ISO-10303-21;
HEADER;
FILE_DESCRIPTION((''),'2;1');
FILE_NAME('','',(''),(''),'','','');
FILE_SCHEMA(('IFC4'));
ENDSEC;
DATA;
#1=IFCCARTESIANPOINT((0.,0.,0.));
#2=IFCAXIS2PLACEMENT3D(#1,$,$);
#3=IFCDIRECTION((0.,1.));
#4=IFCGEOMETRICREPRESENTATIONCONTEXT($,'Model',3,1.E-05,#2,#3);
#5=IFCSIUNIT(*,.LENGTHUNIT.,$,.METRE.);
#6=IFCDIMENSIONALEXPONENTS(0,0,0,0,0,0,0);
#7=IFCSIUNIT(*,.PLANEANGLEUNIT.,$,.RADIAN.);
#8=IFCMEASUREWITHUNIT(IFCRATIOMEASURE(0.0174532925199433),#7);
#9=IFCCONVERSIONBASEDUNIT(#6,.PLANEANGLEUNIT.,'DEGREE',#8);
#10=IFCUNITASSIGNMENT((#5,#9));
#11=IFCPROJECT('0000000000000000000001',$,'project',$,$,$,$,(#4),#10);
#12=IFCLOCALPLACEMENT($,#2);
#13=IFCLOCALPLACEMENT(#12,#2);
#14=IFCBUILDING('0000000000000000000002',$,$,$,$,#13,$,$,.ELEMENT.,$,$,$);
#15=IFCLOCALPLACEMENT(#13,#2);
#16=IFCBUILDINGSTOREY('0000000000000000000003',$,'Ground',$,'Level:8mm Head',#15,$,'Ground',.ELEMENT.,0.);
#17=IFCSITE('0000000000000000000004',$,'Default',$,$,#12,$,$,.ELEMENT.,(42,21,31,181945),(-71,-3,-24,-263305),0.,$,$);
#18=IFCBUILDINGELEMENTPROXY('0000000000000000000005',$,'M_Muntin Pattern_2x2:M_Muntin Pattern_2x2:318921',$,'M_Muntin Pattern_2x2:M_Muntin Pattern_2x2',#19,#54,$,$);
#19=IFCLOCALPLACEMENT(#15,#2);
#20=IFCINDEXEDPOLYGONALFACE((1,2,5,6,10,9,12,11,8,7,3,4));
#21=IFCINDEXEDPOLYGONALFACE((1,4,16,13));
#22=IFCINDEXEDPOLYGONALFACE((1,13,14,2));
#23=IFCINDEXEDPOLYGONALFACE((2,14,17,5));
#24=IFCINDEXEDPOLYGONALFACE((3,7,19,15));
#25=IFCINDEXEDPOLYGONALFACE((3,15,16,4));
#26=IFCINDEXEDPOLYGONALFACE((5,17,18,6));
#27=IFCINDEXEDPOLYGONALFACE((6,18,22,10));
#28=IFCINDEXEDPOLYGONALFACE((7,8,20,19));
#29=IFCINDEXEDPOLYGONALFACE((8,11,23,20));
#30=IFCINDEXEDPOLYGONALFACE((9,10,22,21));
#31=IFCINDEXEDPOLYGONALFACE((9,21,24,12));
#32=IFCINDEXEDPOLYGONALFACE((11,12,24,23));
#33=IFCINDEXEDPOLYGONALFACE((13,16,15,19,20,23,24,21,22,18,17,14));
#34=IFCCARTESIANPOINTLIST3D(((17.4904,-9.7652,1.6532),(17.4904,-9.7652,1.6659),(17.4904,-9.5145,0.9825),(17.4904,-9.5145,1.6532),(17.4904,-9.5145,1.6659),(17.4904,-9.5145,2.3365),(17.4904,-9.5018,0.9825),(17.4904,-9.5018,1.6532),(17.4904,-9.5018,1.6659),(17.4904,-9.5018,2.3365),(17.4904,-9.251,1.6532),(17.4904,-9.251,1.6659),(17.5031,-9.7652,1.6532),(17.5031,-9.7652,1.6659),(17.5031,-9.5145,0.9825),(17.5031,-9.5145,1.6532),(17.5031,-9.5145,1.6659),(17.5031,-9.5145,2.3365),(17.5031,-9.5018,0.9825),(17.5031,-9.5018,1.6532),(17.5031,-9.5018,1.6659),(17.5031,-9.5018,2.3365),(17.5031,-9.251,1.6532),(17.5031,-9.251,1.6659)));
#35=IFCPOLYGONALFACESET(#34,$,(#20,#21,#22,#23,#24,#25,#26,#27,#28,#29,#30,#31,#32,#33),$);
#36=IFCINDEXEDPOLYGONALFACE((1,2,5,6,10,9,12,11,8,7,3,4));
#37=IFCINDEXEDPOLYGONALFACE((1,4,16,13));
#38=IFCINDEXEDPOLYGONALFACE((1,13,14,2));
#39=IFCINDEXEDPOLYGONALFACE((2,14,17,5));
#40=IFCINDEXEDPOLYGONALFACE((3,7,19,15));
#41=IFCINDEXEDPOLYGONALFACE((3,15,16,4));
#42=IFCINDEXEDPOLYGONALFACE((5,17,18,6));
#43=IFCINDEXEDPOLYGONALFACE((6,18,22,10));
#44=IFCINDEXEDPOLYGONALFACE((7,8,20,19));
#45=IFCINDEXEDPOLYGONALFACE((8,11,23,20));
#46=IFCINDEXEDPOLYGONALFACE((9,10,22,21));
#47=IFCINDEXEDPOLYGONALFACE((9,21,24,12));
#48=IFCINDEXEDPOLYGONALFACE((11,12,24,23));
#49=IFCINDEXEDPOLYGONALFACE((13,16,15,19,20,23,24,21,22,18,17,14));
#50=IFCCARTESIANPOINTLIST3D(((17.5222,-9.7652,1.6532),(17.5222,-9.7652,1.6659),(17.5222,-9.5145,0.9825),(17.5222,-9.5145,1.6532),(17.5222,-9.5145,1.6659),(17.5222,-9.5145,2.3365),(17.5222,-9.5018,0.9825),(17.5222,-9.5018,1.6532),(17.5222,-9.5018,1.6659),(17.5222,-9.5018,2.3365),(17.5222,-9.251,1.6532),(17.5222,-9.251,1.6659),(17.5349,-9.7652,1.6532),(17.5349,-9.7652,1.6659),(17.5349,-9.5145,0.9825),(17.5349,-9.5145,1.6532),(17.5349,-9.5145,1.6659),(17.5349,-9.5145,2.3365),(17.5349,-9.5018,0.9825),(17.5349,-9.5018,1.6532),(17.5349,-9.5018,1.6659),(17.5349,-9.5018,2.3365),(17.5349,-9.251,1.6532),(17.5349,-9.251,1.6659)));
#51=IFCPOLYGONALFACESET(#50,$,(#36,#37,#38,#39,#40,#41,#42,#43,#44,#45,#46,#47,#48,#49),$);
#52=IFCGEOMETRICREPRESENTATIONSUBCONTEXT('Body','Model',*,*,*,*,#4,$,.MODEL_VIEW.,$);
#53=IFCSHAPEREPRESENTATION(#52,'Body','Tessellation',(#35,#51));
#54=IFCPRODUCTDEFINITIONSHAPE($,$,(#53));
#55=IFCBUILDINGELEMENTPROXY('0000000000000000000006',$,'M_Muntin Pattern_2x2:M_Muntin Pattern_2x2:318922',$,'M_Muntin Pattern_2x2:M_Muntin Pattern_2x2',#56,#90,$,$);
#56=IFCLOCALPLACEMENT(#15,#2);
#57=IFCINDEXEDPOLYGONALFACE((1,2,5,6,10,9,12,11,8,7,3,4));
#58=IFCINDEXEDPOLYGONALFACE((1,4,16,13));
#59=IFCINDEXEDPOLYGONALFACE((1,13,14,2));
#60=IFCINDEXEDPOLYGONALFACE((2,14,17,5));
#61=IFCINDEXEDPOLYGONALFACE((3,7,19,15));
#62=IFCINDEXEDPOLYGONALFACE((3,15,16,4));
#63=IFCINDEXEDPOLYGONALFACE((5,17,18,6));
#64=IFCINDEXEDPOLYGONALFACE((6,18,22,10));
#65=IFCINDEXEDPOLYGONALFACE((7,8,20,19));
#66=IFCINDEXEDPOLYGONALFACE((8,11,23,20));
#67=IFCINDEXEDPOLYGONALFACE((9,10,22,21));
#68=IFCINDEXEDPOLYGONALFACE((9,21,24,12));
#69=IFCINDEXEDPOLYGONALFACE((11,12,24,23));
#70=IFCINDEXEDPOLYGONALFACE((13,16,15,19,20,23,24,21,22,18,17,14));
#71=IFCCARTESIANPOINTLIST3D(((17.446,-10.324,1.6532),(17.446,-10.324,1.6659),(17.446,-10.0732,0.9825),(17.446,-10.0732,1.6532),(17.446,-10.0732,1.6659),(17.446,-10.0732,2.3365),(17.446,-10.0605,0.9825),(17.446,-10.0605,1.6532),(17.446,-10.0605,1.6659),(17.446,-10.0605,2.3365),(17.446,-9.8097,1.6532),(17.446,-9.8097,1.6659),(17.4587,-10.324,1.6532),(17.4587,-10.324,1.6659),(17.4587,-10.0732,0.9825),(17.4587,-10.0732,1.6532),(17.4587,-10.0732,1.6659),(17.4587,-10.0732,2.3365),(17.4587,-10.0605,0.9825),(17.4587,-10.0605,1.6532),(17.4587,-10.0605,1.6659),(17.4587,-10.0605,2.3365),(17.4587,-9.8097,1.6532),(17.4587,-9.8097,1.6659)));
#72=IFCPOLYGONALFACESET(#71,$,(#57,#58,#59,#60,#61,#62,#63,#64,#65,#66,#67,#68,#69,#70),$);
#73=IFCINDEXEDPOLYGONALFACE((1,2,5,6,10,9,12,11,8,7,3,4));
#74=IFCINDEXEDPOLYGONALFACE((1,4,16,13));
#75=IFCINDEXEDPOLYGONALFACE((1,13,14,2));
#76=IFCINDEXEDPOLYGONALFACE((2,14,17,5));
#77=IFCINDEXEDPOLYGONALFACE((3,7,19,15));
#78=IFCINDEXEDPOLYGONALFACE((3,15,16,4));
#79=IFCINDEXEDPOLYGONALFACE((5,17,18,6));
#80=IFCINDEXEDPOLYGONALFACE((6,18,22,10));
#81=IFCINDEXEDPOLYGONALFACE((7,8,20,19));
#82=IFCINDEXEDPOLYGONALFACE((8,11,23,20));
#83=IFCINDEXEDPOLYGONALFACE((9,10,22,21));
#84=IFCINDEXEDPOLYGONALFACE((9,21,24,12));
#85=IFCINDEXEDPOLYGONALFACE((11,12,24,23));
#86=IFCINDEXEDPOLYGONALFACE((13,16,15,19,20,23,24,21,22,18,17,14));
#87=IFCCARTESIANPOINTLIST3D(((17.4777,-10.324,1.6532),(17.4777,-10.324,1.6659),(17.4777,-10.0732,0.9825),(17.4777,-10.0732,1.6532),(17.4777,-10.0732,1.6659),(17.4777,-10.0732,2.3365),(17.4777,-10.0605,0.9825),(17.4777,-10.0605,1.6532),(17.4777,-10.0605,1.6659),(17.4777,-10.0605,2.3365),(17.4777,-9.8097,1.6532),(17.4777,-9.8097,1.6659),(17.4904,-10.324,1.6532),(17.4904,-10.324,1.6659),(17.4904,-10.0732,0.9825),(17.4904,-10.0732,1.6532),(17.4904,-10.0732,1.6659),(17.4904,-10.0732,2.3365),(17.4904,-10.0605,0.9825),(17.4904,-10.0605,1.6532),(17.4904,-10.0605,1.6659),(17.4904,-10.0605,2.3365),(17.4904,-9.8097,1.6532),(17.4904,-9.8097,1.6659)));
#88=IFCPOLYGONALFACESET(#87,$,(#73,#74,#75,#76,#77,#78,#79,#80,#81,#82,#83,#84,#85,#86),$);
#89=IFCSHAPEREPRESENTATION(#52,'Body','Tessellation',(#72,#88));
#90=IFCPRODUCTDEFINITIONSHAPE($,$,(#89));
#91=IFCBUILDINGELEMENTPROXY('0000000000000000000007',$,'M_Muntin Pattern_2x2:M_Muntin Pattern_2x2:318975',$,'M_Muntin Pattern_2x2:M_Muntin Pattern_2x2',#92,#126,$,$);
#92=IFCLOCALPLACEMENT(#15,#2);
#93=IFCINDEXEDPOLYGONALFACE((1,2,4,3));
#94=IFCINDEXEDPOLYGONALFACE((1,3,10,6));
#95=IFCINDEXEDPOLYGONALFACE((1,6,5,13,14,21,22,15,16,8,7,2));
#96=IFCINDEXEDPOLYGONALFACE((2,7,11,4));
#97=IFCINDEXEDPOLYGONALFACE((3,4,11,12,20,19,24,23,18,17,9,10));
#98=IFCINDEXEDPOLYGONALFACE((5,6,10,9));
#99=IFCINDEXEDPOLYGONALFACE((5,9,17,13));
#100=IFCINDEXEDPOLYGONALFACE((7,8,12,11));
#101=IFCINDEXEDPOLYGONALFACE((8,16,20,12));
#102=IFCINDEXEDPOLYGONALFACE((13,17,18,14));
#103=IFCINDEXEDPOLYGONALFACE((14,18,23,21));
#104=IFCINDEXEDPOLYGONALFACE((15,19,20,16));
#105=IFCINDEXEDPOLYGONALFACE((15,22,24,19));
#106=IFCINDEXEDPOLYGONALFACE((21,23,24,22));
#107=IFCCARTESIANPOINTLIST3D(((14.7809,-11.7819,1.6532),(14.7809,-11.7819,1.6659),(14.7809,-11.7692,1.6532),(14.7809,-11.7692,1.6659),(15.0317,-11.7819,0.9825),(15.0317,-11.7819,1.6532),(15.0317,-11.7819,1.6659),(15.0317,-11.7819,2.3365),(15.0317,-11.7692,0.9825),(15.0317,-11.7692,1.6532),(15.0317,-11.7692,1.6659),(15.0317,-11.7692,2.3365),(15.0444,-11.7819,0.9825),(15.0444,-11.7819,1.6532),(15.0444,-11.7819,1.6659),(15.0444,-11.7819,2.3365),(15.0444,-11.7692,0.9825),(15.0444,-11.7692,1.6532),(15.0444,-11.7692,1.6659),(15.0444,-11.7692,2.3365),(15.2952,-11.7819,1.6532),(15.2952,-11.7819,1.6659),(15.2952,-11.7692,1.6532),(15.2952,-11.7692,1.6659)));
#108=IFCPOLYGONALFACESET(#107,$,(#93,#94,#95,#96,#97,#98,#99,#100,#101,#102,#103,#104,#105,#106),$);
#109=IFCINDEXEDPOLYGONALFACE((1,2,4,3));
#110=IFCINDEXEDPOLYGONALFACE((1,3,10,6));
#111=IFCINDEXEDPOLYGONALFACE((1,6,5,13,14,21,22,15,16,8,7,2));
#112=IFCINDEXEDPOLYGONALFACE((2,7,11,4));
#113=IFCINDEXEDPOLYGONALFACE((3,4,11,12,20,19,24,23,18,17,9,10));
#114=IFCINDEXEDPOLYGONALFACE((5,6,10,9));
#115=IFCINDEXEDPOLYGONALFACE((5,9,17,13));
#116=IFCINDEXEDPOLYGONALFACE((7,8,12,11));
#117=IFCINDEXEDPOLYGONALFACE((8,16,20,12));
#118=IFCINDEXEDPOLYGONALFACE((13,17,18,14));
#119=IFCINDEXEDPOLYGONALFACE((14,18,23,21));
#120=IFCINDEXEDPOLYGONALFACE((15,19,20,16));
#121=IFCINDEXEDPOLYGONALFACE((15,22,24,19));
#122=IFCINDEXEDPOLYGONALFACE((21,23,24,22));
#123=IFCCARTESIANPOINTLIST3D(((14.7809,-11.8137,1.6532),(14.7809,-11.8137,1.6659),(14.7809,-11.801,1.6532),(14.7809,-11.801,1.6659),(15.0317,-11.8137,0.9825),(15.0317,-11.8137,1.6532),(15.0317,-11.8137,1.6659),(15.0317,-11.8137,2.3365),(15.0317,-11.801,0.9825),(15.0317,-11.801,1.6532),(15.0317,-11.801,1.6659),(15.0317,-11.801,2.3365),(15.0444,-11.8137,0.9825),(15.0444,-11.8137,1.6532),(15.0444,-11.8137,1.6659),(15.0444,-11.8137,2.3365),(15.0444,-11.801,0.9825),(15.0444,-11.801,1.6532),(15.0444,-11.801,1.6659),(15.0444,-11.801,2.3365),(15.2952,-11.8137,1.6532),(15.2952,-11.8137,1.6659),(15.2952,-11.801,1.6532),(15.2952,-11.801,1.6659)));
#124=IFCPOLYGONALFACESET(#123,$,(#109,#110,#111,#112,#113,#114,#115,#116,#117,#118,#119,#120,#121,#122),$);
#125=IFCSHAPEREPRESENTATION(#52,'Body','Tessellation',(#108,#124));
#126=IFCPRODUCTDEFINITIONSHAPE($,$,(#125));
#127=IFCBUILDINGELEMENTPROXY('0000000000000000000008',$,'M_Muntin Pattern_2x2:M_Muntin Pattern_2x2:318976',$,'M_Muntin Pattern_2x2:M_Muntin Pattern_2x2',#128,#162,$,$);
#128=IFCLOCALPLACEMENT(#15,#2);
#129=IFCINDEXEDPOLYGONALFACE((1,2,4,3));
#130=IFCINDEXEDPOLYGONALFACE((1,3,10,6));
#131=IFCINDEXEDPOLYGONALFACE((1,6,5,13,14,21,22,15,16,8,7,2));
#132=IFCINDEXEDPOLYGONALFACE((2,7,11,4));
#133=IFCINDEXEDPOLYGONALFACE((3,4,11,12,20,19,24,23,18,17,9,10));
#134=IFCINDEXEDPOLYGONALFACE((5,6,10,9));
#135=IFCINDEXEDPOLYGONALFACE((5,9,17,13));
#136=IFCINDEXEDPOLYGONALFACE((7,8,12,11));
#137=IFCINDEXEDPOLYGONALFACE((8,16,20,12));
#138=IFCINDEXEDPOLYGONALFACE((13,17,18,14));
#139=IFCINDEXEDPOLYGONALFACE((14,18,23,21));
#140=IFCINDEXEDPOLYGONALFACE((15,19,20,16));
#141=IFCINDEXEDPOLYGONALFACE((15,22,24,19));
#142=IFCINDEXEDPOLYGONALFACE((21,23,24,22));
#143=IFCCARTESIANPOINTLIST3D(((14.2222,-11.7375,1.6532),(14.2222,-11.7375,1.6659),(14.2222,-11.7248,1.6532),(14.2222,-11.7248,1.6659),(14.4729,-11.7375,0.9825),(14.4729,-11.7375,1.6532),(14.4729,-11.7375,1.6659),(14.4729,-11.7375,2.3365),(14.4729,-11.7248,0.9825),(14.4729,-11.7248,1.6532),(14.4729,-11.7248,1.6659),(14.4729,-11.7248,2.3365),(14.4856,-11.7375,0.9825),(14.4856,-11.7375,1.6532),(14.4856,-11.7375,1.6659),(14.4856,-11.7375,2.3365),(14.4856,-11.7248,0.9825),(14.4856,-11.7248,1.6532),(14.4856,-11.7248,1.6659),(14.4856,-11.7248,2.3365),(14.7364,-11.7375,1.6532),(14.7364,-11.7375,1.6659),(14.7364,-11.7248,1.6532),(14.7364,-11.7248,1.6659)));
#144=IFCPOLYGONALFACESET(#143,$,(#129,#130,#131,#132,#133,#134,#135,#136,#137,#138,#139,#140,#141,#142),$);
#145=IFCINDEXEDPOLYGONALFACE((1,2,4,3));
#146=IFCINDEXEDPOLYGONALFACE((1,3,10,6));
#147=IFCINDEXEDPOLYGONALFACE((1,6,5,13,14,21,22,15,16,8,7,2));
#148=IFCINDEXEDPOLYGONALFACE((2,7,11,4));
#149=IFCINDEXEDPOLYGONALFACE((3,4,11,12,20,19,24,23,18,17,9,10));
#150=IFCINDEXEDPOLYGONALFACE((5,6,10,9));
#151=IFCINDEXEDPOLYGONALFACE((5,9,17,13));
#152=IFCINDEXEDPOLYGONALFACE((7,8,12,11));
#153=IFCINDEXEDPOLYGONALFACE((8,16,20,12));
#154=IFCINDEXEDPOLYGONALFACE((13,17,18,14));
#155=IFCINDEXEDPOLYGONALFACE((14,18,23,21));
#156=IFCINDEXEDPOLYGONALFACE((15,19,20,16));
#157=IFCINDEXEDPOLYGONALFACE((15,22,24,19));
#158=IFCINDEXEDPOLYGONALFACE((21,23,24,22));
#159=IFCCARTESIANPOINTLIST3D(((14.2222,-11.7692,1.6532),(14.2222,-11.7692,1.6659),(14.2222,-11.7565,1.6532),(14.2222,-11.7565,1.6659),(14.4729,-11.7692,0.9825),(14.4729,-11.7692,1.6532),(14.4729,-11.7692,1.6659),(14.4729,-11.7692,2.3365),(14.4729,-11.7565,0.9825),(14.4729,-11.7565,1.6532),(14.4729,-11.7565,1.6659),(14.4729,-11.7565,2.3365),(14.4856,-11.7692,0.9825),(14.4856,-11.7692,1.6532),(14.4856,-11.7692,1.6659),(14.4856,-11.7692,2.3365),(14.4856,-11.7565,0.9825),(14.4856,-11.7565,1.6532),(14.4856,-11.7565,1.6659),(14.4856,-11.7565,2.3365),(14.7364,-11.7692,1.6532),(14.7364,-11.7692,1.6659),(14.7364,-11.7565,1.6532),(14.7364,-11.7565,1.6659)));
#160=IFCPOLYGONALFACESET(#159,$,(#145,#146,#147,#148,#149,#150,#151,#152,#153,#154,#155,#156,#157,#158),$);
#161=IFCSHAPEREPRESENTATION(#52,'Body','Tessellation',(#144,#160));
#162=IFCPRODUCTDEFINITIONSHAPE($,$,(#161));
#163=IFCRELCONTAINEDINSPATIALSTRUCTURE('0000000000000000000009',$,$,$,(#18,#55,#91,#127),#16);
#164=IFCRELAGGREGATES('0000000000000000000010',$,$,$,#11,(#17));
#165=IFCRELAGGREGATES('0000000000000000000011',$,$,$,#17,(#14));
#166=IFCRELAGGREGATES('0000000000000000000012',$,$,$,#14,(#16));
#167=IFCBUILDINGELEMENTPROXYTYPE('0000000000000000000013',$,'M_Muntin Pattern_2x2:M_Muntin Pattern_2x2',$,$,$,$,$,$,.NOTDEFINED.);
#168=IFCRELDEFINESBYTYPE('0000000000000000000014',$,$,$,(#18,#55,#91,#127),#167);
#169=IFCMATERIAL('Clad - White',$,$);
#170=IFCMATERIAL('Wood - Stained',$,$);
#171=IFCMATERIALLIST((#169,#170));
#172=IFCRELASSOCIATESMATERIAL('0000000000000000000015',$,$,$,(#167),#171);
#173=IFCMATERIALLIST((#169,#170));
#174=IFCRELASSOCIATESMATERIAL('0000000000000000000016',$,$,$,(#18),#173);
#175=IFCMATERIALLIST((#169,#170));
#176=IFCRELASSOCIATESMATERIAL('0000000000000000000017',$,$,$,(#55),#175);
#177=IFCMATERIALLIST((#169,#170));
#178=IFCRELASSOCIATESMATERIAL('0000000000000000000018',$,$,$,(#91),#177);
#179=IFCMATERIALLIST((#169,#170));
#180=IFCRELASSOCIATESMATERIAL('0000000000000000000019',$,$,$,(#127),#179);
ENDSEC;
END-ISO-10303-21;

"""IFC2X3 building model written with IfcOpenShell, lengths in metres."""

from ifc_helpers import new_model, entity, si_unit, converted_unit, direction, frame, origin, place, context, subcontext, project, spatial, polyline, outline, extrude, source, transform, mapped, material, material_list, type_object, type_shapes, element, save


model = new_model("IFC2X3")

# Units and contexts
model_context = context("Model", 3, precision=1e-05, world=origin(), true_north=direction((0.0, 1.0)))
body_context = subcontext(model_context, "Body", "Model", "MODEL_VIEW")
ifc_project = project(units=[si_unit("LENGTHUNIT", "METRE"), converted_unit("PLANEANGLEUNIT", "DEGREE", entity("IfcRatioMeasure", 0.0174532925199433), si_unit("PLANEANGLEUNIT", "RADIAN"), dimensions=[0, 0, 0, 0, 0, 0, 0])], contexts=[model_context])

# Site, building, storey
site_placement = place(None, origin())
site = spatial("IfcSite", under=ifc_project, at=site_placement, Name="Default", CompositionType="ELEMENT", RefLatitude=(42, 21, 31, 181945), RefLongitude=(-71, -3, -24, -263305), RefElevation=0.0)
building_placement = place(site_placement, origin())
building = spatial("IfcBuilding", under=site, at=building_placement, CompositionType="ELEMENT")
storey_placement = place(building_placement, origin())
storey = spatial("IfcBuildingStorey", under=building, at=storey_placement, Name="Ground", ObjectType="Level:8mm Head", LongName="Ground", CompositionType="ELEMENT", Elevation=0.0)

# Building element proxies
ifc_material_1 = material(Name="Clad - White")
ifc_material_2 = material(Name="Wood - Stained")
ifc_material_list_1 = material_list([ifc_material_1, ifc_material_2])
building_element_proxy_type_1 = type_object("IfcBuildingElementProxyType", Name="M_Muntin Pattern_2x2:M_Muntin Pattern_2x2", PredefinedType="NOTDEFINED", material=ifc_material_list_1)
shared_shape_1 = source(origin(), body_context, "Body", "SweptSolid", [
    extrude(outline(polyline([(0.0064, -0.0064), (0.677, -0.0064), (0.677, 0.0063), (0.0064, 0.0063), (0.0064, 0.2571), (-0.0063, 0.2571), (-0.0063, 0.0063), (-0.677, 0.0063), (-0.677, -0.0064), (-0.0063, -0.0064), (-0.0063, -0.2571), (0.0064, -0.2571), (0.0064, -0.0064)])), frame((0.0, 0.0095, 0.677), z_axis=(0.0, 1.0, 0.0), x_axis=(0.0, 0.0, 1.0)), (0.0, 0.0, 1.0), 0.0127),
    extrude(outline(polyline([(0.0064, -0.0064), (0.677, -0.0064), (0.677, 0.0063), (0.0064, 0.0063), (0.0064, 0.2571), (-0.0063, 0.2571), (-0.0063, 0.0063), (-0.677, 0.0063), (-0.677, -0.0064), (-0.0063, -0.0064), (-0.0063, -0.2571), (0.0064, -0.2571), (0.0064, -0.0064)])), frame((0.0, -0.0222, 0.677), z_axis=(0.0, 1.0, 0.0), x_axis=(0.0, 0.0, 1.0)), (0.0, 0.0, 1.0), 0.0127),
])
type_shapes(building_element_proxy_type_1, [shared_shape_1])
ifc_material_list_2 = material_list([ifc_material_1, ifc_material_2])
proxy_1_placement = place(storey_placement, frame((17.5126, -9.5081, 0.9825), z_axis=(0.0, 0.0, 1.0), x_axis=(0.0, 1.0, 0.0)))
element("IfcBuildingElementProxy", 1, at=proxy_1_placement, inside=storey, type_object=building_element_proxy_type_1, material=ifc_material_list_2, Name="M_Muntin Pattern_2x2:M_Muntin Pattern_2x2:318921", ObjectType="M_Muntin Pattern_2x2:M_Muntin Pattern_2x2", context=body_context, shape_type="MappedRepresentation", body=[
    mapped(shared_shape_1, transform((0.0, 0.0, 0.0), scale=1.0)),
])
ifc_material_list_3 = material_list([ifc_material_1, ifc_material_2])
proxy_2_placement = place(storey_placement, frame((17.4682, -10.0668, 0.9825), z_axis=(0.0, 0.0, 1.0), x_axis=(0.0, 1.0, 0.0)))
element("IfcBuildingElementProxy", 2, at=proxy_2_placement, inside=storey, type_object=building_element_proxy_type_1, material=ifc_material_list_3, Name="M_Muntin Pattern_2x2:M_Muntin Pattern_2x2:318922", ObjectType="M_Muntin Pattern_2x2:M_Muntin Pattern_2x2", context=body_context, shape_type="MappedRepresentation", body=[
    mapped(shared_shape_1, transform((0.0, 0.0, 0.0), scale=1.0)),
])
ifc_material_list_4 = material_list([ifc_material_1, ifc_material_2])
proxy_3_placement = place(storey_placement, frame((15.038, -11.7914, 0.9825)))
element("IfcBuildingElementProxy", 3, at=proxy_3_placement, inside=storey, type_object=building_element_proxy_type_1, material=ifc_material_list_4, Name="M_Muntin Pattern_2x2:M_Muntin Pattern_2x2:318975", ObjectType="M_Muntin Pattern_2x2:M_Muntin Pattern_2x2", context=body_context, shape_type="MappedRepresentation", body=[
    mapped(shared_shape_1, transform((0.0, 0.0, 0.0), scale=1.0)),
])
ifc_material_list_5 = material_list([ifc_material_1, ifc_material_2])
proxy_4_placement = place(storey_placement, frame((14.4793, -11.747, 0.9825)))
element("IfcBuildingElementProxy", 4, at=proxy_4_placement, inside=storey, type_object=building_element_proxy_type_1, material=ifc_material_list_5, Name="M_Muntin Pattern_2x2:M_Muntin Pattern_2x2:318976", ObjectType="M_Muntin Pattern_2x2:M_Muntin Pattern_2x2", context=body_context, shape_type="MappedRepresentation", body=[
    mapped(shared_shape_1, transform((0.0, 0.0, 0.0), scale=1.0)),
])

save(model, "model.ifc")
